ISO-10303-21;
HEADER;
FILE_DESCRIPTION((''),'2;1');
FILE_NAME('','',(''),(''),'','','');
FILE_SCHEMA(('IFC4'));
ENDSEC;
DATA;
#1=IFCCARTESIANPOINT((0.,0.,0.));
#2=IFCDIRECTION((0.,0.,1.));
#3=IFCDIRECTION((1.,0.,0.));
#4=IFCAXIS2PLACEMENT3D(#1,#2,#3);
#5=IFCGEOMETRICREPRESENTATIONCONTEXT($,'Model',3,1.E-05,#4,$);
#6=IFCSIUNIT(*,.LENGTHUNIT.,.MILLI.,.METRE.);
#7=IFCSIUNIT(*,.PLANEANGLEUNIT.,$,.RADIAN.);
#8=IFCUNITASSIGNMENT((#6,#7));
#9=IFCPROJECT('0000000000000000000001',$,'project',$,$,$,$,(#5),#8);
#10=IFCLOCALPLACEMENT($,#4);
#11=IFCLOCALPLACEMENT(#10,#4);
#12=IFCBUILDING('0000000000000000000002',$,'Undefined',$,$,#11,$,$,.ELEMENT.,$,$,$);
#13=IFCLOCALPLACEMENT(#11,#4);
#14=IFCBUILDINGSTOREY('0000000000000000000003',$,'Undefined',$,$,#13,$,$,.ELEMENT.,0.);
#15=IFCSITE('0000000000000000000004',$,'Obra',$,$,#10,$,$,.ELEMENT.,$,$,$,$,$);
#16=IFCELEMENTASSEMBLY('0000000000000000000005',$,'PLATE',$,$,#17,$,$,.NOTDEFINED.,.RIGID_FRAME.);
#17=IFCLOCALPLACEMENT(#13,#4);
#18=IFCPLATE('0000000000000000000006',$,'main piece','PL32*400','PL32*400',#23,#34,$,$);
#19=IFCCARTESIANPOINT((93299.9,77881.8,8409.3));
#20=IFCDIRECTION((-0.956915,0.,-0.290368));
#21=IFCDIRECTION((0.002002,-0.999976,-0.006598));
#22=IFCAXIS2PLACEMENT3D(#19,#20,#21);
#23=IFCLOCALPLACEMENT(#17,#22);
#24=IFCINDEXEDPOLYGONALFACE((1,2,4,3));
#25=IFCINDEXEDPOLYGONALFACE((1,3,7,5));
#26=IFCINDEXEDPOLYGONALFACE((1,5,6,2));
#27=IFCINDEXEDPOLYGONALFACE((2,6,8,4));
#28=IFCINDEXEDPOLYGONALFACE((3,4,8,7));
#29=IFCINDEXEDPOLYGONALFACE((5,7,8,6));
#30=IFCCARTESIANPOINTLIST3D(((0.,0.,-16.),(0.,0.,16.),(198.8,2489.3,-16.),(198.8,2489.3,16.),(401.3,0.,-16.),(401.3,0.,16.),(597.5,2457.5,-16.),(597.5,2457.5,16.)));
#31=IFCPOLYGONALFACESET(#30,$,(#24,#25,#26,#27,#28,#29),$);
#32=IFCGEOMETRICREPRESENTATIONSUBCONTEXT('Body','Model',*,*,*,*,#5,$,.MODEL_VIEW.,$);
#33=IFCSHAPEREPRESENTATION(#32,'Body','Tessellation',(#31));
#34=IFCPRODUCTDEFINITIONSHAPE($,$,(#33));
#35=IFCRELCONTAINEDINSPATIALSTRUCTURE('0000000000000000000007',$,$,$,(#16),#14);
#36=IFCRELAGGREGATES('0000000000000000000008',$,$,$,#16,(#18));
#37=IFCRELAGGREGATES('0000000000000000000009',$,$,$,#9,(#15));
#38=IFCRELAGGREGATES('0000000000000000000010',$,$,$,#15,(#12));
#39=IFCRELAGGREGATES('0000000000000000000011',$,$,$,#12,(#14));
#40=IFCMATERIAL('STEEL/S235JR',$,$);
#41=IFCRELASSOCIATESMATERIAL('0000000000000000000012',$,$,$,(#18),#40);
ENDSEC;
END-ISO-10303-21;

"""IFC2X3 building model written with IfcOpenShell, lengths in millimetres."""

from ifc_helpers import new_model, si_unit, frame, origin_with_axes, place, context, subcontext, project, spatial, polyline, outline, extrude, material, element, aggregate, save


model = new_model("IFC2X3")

# Units and contexts
model_context = context("Model", 3, precision=1e-05, world=origin_with_axes())
body_context = subcontext(model_context, "Body", "Model", "MODEL_VIEW")
ifc_project = project(units=[si_unit("LENGTHUNIT", "METRE", prefix="MILLI"), si_unit("PLANEANGLEUNIT", "RADIAN")], contexts=[model_context])

# Site, building, storey
site_placement = place(None, origin_with_axes())
site = spatial("IfcSite", under=ifc_project, at=site_placement, Name="Obra", CompositionType="ELEMENT")
building_placement = place(site_placement, origin_with_axes())
building = spatial("IfcBuilding", under=site, at=building_placement, Name="Undefined", CompositionType="ELEMENT")
storey_placement = place(building_placement, origin_with_axes())
storey = spatial("IfcBuildingStorey", under=building, at=storey_placement, Name="Undefined", CompositionType="ELEMENT", Elevation=0.0)

# Shared definitions
ifc_material_1 = material(Name="STEEL/S235JR")

# Element assembly, plate
assembly_1_placement = place(storey_placement, origin_with_axes())
assembly_1 = element("IfcElementAssembly", 1, at=assembly_1_placement, inside=storey, Name="PLATE", AssemblyPlace="NOTDEFINED", PredefinedType="RIGID_FRAME")
plate_1_placement = place(assembly_1_placement, frame((93299.9, 77881.8, 8409.3), z_axis=(-0.956915, 0.0, -0.290368), x_axis=(0.002002, -0.999976, -0.006598)))
plate_1 = element("IfcPlate", 2, at=plate_1_placement, material=ifc_material_1, Name="main piece", Description="PL32*400", ObjectType="PL32*400", context=body_context, shape_type="SweptSolid", body=[
    extrude(outline(polyline([(0.0, 0.0), (401.3, 0.0), (597.5, 2457.5), (198.8, 2489.3), (0.0, 0.0)])), frame((0.0, 0.0, -16.0), z_axis=(0.0, 0.0, 1.0), x_axis=(1.0, 0.0, 0.0)), (0.0, 0.0, 1.0), 32.0),
])
aggregate(assembly_1, [plate_1])

save(model, "model.ifc")
